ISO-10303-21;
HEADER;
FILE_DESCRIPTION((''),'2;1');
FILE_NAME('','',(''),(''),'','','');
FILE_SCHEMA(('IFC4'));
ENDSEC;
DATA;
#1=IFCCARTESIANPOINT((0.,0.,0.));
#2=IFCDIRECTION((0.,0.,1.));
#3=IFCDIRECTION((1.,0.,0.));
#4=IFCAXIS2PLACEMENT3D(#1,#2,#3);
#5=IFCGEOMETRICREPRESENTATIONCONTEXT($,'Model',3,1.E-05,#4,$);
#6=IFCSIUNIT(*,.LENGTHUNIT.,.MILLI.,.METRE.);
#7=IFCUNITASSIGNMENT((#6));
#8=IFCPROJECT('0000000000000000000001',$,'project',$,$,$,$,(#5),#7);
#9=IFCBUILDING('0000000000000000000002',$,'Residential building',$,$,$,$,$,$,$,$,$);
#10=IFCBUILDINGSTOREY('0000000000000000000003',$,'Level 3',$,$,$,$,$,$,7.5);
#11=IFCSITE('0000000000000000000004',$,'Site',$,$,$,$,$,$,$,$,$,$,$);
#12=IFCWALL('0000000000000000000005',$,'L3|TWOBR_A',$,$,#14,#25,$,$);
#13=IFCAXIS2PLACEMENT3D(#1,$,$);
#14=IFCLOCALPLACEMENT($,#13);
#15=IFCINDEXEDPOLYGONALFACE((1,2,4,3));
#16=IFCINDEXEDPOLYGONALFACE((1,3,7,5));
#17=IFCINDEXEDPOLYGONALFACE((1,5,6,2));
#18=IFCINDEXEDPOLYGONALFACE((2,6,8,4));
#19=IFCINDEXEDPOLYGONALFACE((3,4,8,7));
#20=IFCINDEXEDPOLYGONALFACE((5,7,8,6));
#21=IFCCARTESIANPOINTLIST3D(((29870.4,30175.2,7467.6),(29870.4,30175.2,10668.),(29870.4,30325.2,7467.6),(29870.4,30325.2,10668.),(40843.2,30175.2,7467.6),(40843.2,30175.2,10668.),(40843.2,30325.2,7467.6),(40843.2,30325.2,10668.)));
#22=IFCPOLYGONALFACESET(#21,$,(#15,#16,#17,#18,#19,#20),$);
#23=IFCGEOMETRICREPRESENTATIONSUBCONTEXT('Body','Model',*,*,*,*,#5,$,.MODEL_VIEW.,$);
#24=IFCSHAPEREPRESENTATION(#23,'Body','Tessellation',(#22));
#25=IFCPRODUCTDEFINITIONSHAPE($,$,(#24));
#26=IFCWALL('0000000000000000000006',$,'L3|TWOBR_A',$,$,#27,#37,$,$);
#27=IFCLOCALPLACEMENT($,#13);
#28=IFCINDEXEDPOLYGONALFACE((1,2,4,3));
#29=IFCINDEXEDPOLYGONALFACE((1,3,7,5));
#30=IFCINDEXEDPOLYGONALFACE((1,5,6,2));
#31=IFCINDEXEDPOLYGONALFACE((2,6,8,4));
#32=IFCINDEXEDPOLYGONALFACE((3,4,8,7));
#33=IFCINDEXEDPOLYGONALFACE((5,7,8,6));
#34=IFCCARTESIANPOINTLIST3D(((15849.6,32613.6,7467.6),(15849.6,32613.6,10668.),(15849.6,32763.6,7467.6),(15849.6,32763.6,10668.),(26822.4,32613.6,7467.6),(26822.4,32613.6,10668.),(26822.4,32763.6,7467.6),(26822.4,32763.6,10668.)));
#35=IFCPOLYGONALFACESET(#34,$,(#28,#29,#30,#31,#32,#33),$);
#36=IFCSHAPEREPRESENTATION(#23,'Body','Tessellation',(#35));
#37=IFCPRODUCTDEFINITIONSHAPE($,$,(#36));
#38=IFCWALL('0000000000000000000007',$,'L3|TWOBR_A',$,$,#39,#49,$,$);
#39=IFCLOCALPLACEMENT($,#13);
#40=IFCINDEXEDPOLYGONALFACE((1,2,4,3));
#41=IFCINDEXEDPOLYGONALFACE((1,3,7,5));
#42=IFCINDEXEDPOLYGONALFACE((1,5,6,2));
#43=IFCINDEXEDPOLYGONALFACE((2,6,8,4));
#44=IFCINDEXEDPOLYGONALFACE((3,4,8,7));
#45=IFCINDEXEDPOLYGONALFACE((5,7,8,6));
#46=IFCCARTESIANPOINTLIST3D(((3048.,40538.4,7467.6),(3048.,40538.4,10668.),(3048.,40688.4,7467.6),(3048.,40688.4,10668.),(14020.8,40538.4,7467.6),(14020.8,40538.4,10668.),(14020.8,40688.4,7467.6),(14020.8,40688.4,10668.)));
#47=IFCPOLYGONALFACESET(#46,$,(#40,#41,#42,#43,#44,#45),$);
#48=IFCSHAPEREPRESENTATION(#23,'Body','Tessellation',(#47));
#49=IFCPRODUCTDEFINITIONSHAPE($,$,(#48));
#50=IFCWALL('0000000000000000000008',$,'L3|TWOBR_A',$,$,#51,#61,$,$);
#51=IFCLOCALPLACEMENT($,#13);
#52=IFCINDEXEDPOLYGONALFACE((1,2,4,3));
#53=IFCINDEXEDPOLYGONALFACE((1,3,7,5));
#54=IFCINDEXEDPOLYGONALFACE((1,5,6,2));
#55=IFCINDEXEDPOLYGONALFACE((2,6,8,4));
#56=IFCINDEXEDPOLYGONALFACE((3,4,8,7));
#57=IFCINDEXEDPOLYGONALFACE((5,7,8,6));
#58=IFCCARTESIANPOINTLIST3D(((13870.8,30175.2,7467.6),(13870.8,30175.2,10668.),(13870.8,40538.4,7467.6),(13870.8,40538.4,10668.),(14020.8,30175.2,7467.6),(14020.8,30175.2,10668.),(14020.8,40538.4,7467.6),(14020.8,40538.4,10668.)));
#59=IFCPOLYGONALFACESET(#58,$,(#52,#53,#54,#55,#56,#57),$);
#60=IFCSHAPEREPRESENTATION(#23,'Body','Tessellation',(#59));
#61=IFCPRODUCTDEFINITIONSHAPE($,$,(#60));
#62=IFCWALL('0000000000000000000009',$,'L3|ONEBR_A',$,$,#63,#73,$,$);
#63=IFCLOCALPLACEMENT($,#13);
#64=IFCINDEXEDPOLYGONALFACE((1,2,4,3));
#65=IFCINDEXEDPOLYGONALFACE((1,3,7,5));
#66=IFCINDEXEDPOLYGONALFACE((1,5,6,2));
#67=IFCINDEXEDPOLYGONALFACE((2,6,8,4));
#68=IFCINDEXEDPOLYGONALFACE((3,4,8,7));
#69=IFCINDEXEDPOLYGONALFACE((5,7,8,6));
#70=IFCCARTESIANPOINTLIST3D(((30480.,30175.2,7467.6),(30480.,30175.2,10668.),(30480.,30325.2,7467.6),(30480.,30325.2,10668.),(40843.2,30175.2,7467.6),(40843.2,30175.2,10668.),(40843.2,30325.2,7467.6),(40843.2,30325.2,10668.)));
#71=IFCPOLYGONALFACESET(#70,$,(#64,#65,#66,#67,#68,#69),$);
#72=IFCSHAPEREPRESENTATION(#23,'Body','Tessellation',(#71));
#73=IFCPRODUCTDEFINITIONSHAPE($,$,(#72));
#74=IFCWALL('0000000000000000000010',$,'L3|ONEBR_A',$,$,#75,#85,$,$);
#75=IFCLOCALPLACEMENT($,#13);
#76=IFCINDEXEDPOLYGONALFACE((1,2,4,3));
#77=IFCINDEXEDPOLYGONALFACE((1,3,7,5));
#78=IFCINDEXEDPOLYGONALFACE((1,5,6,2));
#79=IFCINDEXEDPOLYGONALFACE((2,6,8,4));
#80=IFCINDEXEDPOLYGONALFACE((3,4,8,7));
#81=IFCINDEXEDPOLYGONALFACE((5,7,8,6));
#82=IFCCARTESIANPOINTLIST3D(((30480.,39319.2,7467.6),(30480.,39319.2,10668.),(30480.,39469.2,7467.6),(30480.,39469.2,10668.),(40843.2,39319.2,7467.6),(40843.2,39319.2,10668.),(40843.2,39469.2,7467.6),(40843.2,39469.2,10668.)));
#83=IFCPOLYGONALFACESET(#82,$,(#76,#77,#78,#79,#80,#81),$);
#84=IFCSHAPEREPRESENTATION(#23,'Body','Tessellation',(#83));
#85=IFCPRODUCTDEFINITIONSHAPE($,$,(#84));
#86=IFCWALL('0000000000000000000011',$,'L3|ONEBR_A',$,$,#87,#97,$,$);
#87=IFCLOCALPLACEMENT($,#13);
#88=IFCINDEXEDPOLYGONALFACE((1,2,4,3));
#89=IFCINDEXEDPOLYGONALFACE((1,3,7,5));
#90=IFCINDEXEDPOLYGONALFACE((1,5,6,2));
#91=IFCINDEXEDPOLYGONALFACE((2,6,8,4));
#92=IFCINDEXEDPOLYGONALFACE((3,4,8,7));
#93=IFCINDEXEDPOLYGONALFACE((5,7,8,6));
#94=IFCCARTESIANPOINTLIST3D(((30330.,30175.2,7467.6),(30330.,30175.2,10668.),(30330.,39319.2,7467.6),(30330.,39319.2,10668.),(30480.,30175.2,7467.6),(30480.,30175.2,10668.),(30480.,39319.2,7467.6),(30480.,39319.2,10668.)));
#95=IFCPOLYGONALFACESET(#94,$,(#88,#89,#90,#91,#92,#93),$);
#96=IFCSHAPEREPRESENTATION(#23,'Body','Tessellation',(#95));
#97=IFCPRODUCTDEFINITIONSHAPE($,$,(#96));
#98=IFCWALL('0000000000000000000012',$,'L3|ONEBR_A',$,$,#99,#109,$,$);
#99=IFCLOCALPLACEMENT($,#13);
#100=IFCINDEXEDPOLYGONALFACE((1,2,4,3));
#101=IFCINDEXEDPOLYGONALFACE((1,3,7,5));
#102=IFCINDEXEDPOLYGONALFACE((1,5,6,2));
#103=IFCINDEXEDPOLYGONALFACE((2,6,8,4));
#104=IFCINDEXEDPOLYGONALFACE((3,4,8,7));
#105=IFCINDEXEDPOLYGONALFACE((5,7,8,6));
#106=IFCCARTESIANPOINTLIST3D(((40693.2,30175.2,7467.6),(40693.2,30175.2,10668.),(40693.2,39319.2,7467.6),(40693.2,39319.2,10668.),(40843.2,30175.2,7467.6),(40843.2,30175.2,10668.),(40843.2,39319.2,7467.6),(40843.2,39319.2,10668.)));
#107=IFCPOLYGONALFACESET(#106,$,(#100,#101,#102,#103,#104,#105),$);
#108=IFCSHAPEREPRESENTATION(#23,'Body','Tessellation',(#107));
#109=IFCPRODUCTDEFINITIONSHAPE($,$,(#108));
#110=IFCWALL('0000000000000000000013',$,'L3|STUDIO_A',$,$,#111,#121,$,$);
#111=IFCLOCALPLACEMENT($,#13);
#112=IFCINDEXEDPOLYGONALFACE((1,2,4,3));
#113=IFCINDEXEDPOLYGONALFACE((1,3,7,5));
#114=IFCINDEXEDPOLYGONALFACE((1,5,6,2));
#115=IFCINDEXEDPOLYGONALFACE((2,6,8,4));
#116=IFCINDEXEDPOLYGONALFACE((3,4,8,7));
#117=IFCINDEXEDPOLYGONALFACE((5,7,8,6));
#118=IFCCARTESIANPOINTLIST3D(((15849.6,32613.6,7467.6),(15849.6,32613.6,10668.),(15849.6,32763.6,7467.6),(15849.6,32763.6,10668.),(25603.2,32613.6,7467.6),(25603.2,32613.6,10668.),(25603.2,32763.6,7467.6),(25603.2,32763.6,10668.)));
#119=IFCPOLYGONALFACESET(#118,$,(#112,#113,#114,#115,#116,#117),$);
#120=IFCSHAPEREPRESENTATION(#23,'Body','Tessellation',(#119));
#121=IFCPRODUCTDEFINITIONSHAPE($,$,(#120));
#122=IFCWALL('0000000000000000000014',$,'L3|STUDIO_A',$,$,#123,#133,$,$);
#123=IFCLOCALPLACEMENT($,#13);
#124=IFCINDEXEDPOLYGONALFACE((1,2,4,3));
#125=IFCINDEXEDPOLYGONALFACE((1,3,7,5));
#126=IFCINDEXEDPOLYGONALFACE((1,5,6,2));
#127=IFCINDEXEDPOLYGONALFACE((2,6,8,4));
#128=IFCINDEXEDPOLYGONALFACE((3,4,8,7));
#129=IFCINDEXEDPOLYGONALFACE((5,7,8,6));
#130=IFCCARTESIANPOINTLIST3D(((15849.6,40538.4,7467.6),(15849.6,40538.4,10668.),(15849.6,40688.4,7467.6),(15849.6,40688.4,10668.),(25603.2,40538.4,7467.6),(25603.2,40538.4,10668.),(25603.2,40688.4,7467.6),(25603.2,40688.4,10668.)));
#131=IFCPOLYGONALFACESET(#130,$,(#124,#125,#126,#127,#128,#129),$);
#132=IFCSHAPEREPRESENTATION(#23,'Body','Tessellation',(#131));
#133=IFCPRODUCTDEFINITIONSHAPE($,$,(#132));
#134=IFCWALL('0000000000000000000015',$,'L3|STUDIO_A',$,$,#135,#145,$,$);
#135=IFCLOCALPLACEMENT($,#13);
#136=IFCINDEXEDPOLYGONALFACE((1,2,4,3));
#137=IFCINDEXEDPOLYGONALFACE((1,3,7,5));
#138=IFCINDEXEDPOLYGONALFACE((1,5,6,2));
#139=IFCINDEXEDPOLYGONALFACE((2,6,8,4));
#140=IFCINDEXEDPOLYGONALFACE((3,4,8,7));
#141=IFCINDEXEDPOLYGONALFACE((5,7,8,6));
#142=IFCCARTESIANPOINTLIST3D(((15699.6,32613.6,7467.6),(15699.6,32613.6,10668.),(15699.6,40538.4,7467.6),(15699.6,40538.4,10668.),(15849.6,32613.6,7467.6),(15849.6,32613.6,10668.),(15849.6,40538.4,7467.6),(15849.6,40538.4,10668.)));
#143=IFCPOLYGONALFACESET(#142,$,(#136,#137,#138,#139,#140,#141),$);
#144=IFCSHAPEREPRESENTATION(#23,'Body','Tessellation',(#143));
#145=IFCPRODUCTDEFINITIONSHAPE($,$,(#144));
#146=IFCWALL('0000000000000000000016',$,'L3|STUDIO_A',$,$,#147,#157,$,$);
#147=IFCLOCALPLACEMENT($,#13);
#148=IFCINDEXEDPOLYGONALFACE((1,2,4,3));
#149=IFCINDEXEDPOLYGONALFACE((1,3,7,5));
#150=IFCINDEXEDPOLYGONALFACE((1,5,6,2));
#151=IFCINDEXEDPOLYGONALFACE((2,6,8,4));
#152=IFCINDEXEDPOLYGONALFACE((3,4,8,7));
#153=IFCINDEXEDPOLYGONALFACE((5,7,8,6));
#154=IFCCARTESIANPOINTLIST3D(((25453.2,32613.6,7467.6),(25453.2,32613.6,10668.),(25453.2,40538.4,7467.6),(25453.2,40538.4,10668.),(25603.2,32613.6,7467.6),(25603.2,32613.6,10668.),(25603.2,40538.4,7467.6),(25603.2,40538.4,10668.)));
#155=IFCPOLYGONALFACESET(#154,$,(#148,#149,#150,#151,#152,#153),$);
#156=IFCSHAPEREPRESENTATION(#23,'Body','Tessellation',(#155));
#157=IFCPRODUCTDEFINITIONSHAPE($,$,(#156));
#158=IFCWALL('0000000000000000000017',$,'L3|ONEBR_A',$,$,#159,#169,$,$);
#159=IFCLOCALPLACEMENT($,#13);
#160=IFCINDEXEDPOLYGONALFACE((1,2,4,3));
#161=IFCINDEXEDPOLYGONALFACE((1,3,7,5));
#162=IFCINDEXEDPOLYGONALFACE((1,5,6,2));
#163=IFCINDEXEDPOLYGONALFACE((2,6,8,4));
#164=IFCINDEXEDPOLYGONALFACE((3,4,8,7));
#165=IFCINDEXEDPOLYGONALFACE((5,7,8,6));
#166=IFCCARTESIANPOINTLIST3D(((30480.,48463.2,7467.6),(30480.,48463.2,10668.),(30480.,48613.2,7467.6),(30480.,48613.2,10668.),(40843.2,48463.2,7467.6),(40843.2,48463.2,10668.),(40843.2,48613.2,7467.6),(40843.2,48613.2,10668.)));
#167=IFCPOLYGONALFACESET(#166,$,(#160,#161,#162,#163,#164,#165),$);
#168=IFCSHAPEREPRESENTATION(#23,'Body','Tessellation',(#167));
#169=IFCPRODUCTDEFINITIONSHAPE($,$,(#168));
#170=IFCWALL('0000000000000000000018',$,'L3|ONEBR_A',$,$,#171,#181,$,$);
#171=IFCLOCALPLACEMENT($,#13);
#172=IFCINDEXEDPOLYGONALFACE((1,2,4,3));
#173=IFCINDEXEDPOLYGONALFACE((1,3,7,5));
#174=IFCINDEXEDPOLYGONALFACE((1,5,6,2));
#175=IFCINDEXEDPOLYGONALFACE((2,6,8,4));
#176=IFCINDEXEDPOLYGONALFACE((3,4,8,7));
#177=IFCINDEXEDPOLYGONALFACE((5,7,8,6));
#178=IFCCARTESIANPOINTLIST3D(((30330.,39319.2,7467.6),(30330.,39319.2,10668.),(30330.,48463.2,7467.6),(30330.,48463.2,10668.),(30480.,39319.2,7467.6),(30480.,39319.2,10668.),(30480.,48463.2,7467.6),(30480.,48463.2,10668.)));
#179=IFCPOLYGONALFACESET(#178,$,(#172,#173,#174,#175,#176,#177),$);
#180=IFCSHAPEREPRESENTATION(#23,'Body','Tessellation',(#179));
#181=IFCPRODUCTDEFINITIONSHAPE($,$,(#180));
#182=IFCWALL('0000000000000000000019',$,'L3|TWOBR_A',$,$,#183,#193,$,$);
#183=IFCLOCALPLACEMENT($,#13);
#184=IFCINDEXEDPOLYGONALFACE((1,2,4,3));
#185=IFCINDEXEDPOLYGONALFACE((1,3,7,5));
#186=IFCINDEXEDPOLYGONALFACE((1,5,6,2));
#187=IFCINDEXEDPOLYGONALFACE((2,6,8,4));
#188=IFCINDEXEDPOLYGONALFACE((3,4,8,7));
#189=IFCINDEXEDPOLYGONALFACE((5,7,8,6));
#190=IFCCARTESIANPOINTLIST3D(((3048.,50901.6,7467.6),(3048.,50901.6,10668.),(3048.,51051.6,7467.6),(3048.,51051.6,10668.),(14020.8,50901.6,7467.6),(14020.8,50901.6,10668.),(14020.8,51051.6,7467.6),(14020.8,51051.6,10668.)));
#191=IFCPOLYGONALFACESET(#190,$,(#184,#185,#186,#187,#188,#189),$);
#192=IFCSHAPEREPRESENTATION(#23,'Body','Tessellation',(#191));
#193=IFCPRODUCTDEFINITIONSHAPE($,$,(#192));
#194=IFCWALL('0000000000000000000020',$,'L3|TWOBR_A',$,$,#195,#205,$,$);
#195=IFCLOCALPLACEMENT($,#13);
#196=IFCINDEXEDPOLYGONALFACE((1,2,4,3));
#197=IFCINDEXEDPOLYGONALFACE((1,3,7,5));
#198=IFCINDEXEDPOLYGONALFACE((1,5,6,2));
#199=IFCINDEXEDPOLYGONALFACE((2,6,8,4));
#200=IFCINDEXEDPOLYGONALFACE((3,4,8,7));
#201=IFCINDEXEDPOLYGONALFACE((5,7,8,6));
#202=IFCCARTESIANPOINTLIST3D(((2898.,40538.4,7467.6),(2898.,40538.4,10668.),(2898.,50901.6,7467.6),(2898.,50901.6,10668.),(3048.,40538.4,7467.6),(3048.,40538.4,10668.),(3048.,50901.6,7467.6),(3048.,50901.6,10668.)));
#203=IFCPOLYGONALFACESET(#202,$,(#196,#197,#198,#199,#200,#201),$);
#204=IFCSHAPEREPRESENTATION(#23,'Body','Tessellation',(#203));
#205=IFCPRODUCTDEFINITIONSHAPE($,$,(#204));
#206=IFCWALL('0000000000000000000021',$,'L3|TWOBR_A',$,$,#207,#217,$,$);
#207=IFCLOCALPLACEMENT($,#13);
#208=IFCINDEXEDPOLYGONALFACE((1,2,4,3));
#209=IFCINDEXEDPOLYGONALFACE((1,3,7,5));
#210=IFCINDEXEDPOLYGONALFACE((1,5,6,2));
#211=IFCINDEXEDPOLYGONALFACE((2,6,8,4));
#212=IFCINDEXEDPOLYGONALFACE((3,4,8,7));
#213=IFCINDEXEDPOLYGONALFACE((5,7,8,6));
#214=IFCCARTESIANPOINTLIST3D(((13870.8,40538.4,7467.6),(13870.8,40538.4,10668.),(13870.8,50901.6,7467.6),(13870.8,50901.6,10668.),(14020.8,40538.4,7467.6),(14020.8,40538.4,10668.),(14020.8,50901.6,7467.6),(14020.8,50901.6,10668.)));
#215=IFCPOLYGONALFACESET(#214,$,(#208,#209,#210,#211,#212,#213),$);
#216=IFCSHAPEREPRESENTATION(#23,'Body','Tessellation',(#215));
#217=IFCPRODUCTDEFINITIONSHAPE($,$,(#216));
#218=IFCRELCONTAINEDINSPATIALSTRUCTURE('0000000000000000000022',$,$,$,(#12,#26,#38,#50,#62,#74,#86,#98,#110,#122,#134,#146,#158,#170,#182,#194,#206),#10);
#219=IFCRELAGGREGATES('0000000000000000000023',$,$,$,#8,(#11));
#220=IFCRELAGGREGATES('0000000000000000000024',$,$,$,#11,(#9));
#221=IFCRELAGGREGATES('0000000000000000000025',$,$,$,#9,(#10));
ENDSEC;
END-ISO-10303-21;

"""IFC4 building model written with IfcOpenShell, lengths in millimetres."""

from ifc_helpers import new_model, si_unit, frame, origin_with_axes, place, context, subcontext, project, spatial, indexed_curve, outline, extrude, element, save


model = new_model("IFC4")

# Units and contexts
model_context = context("Model", 3, precision=1e-05, world=origin_with_axes())
body_context = subcontext(model_context, "Body", "Model", "MODEL_VIEW")
ifc_project = project(units=[si_unit("LENGTHUNIT", "METRE", prefix="MILLI")], contexts=[model_context])

# Site, building, storey
site = spatial("IfcSite", under=ifc_project, Name="Site")
building = spatial("IfcBuilding", under=site, Name="Residential building")
storey = spatial("IfcBuildingStorey", under=building, Name="Level 3", Elevation=7.5)

# Walls
for number, where, z_axis, x_axis, name in (
    (1, (29870.4, 30175.2, 7467.6), (0.0, 0.0, 1.0), (1.0, 0.0, 0.0), "L3|TWOBR_A"),
    (2, (15849.6, 32613.6, 7467.6), (0.0, 0.0, 1.0), (1.0, 0.0, 0.0), "L3|TWOBR_A"),
    (3, (3048.0, 40538.4, 7467.6), (0.0, 0.0, 1.0), (1.0, 0.0, 0.0), "L3|TWOBR_A"),
):
    element("IfcWall", number, at=place(None, frame(where, z_axis=z_axis, x_axis=x_axis)), inside=storey, Name=name, context=body_context, shape_type="SweptSolid", body=[
        extrude(outline(indexed_curve([(0.0, 0.0), (0.0, 150.0), (10972.8, 150.0), (10972.8, 0.0), (0.0, 0.0)], self_intersect=False)), origin_with_axes(), (0.0, 0.0, 1.0), 3200.4),
    ])
for number, where, z_axis, x_axis, name in (
    (4, (14020.8, 30175.2, 7467.6), (0.0, 0.0, 1.0), (0.0, 1.0, 0.0), "L3|TWOBR_A"),
    (5, (30480.0, 30175.2, 7467.6), (0.0, 0.0, 1.0), (1.0, 0.0, 0.0), "L3|ONEBR_A"),
    (6, (30480.0, 39319.2, 7467.6), (0.0, 0.0, 1.0), (1.0, 0.0, 0.0), "L3|ONEBR_A"),
):
    element("IfcWall", number, at=place(None, frame(where, z_axis=z_axis, x_axis=x_axis)), inside=storey, Name=name, context=body_context, shape_type="SweptSolid", body=[
        extrude(outline(indexed_curve([(0.0, 0.0), (0.0, 150.0), (10363.2, 150.0), (10363.2, 0.0), (0.0, 0.0)], self_intersect=False)), origin_with_axes(), (0.0, 0.0, 1.0), 3200.4),
    ])
for number, where, z_axis, x_axis, name in (
    (7, (30480.0, 30175.2, 7467.6), (0.0, 0.0, 1.0), (0.0, 1.0, 0.0), "L3|ONEBR_A"),
    (8, (40843.2, 30175.2, 7467.6), (0.0, 0.0, 1.0), (0.0, 1.0, 0.0), "L3|ONEBR_A"),
):
    element("IfcWall", number, at=place(None, frame(where, z_axis=z_axis, x_axis=x_axis)), inside=storey, Name=name, context=body_context, shape_type="SweptSolid", body=[
        extrude(outline(indexed_curve([(0.0, 0.0), (0.0, 150.0), (9144.0, 150.0), (9144.0, 0.0), (0.0, 0.0)], self_intersect=False)), origin_with_axes(), (0.0, 0.0, 1.0), 3200.4),
    ])
for number, where, z_axis, x_axis, name in (
    (9, (15849.6, 32613.6, 7467.6), (0.0, 0.0, 1.0), (1.0, 0.0, 0.0), "L3|STUDIO_A"),
    (10, (15849.6, 40538.4, 7467.6), (0.0, 0.0, 1.0), (1.0, 0.0, 0.0), "L3|STUDIO_A"),
):
    element("IfcWall", number, at=place(None, frame(where, z_axis=z_axis, x_axis=x_axis)), inside=storey, Name=name, context=body_context, shape_type="SweptSolid", body=[
        extrude(outline(indexed_curve([(0.0, 0.0), (0.0, 150.0), (9753.6, 150.0), (9753.6, 0.0), (0.0, 0.0)], self_intersect=False)), origin_with_axes(), (0.0, 0.0, 1.0), 3200.4),
    ])
for number, where, z_axis, x_axis, name in (
    (11, (15849.6, 32613.6, 7467.6), (0.0, 0.0, 1.0), (0.0, 1.0, 0.0), "L3|STUDIO_A"),
    (12, (25603.2, 32613.6, 7467.6), (0.0, 0.0, 1.0), (0.0, 1.0, 0.0), "L3|STUDIO_A"),
):
    element("IfcWall", number, at=place(None, frame(where, z_axis=z_axis, x_axis=x_axis)), inside=storey, Name=name, context=body_context, shape_type="SweptSolid", body=[
        extrude(outline(indexed_curve([(0.0, 0.0), (0.0, 150.0), (7924.8, 150.0), (7924.8, 0.0), (0.0, 0.0)], self_intersect=False)), origin_with_axes(), (0.0, 0.0, 1.0), 3200.4),
    ])
for number, where, z_axis, x_axis, name in (
    (13, (30480.0, 48463.2, 7467.6), (0.0, 0.0, 1.0), (1.0, 0.0, 0.0), "L3|ONEBR_A"),
):
    element("IfcWall", number, at=place(None, frame(where, z_axis=z_axis, x_axis=x_axis)), inside=storey, Name=name, context=body_context, shape_type="SweptSolid", body=[
        extrude(outline(indexed_curve([(0.0, 0.0), (0.0, 150.0), (10363.2, 150.0), (10363.2, 0.0), (0.0, 0.0)], self_intersect=False)), origin_with_axes(), (0.0, 0.0, 1.0), 3200.4),
    ])
wall_1_placement = place(None, frame((30480.0, 39319.2, 7467.6), z_axis=(0.0, 0.0, 1.0), x_axis=(0.0, 1.0, 0.0)))
element("IfcWall", 14, at=wall_1_placement, inside=storey, Name="L3|ONEBR_A", context=body_context, shape_type="SweptSolid", body=[
    extrude(outline(indexed_curve([(0.0, 0.0), (0.0, 150.0), (9144.0, 150.0), (9144.0, 0.0), (0.0, 0.0)], self_intersect=False)), origin_with_axes(), (0.0, 0.0, 1.0), 3200.4),
])
for number, where, z_axis, x_axis, name in (
    (15, (3048.0, 50901.6, 7467.6), (0.0, 0.0, 1.0), (1.0, 0.0, 0.0), "L3|TWOBR_A"),
):
    element("IfcWall", number, at=place(None, frame(where, z_axis=z_axis, x_axis=x_axis)), inside=storey, Name=name, context=body_context, shape_type="SweptSolid", body=[
        extrude(outline(indexed_curve([(0.0, 0.0), (0.0, 150.0), (10972.8, 150.0), (10972.8, 0.0), (0.0, 0.0)], self_intersect=False)), origin_with_axes(), (0.0, 0.0, 1.0), 3200.4),
    ])
for number, where, z_axis, x_axis, name in (
    (16, (3048.0, 40538.4, 7467.6), (0.0, 0.0, 1.0), (0.0, 1.0, 0.0), "L3|TWOBR_A"),
    (17, (14020.8, 40538.4, 7467.6), (0.0, 0.0, 1.0), (0.0, 1.0, 0.0), "L3|TWOBR_A"),
):
    element("IfcWall", number, at=place(None, frame(where, z_axis=z_axis, x_axis=x_axis)), inside=storey, Name=name, context=body_context, shape_type="SweptSolid", body=[
        extrude(outline(indexed_curve([(0.0, 0.0), (0.0, 150.0), (10363.2, 150.0), (10363.2, 0.0), (0.0, 0.0)], self_intersect=False)), origin_with_axes(), (0.0, 0.0, 1.0), 3200.4),
    ])

save(model, "model.ifc")
